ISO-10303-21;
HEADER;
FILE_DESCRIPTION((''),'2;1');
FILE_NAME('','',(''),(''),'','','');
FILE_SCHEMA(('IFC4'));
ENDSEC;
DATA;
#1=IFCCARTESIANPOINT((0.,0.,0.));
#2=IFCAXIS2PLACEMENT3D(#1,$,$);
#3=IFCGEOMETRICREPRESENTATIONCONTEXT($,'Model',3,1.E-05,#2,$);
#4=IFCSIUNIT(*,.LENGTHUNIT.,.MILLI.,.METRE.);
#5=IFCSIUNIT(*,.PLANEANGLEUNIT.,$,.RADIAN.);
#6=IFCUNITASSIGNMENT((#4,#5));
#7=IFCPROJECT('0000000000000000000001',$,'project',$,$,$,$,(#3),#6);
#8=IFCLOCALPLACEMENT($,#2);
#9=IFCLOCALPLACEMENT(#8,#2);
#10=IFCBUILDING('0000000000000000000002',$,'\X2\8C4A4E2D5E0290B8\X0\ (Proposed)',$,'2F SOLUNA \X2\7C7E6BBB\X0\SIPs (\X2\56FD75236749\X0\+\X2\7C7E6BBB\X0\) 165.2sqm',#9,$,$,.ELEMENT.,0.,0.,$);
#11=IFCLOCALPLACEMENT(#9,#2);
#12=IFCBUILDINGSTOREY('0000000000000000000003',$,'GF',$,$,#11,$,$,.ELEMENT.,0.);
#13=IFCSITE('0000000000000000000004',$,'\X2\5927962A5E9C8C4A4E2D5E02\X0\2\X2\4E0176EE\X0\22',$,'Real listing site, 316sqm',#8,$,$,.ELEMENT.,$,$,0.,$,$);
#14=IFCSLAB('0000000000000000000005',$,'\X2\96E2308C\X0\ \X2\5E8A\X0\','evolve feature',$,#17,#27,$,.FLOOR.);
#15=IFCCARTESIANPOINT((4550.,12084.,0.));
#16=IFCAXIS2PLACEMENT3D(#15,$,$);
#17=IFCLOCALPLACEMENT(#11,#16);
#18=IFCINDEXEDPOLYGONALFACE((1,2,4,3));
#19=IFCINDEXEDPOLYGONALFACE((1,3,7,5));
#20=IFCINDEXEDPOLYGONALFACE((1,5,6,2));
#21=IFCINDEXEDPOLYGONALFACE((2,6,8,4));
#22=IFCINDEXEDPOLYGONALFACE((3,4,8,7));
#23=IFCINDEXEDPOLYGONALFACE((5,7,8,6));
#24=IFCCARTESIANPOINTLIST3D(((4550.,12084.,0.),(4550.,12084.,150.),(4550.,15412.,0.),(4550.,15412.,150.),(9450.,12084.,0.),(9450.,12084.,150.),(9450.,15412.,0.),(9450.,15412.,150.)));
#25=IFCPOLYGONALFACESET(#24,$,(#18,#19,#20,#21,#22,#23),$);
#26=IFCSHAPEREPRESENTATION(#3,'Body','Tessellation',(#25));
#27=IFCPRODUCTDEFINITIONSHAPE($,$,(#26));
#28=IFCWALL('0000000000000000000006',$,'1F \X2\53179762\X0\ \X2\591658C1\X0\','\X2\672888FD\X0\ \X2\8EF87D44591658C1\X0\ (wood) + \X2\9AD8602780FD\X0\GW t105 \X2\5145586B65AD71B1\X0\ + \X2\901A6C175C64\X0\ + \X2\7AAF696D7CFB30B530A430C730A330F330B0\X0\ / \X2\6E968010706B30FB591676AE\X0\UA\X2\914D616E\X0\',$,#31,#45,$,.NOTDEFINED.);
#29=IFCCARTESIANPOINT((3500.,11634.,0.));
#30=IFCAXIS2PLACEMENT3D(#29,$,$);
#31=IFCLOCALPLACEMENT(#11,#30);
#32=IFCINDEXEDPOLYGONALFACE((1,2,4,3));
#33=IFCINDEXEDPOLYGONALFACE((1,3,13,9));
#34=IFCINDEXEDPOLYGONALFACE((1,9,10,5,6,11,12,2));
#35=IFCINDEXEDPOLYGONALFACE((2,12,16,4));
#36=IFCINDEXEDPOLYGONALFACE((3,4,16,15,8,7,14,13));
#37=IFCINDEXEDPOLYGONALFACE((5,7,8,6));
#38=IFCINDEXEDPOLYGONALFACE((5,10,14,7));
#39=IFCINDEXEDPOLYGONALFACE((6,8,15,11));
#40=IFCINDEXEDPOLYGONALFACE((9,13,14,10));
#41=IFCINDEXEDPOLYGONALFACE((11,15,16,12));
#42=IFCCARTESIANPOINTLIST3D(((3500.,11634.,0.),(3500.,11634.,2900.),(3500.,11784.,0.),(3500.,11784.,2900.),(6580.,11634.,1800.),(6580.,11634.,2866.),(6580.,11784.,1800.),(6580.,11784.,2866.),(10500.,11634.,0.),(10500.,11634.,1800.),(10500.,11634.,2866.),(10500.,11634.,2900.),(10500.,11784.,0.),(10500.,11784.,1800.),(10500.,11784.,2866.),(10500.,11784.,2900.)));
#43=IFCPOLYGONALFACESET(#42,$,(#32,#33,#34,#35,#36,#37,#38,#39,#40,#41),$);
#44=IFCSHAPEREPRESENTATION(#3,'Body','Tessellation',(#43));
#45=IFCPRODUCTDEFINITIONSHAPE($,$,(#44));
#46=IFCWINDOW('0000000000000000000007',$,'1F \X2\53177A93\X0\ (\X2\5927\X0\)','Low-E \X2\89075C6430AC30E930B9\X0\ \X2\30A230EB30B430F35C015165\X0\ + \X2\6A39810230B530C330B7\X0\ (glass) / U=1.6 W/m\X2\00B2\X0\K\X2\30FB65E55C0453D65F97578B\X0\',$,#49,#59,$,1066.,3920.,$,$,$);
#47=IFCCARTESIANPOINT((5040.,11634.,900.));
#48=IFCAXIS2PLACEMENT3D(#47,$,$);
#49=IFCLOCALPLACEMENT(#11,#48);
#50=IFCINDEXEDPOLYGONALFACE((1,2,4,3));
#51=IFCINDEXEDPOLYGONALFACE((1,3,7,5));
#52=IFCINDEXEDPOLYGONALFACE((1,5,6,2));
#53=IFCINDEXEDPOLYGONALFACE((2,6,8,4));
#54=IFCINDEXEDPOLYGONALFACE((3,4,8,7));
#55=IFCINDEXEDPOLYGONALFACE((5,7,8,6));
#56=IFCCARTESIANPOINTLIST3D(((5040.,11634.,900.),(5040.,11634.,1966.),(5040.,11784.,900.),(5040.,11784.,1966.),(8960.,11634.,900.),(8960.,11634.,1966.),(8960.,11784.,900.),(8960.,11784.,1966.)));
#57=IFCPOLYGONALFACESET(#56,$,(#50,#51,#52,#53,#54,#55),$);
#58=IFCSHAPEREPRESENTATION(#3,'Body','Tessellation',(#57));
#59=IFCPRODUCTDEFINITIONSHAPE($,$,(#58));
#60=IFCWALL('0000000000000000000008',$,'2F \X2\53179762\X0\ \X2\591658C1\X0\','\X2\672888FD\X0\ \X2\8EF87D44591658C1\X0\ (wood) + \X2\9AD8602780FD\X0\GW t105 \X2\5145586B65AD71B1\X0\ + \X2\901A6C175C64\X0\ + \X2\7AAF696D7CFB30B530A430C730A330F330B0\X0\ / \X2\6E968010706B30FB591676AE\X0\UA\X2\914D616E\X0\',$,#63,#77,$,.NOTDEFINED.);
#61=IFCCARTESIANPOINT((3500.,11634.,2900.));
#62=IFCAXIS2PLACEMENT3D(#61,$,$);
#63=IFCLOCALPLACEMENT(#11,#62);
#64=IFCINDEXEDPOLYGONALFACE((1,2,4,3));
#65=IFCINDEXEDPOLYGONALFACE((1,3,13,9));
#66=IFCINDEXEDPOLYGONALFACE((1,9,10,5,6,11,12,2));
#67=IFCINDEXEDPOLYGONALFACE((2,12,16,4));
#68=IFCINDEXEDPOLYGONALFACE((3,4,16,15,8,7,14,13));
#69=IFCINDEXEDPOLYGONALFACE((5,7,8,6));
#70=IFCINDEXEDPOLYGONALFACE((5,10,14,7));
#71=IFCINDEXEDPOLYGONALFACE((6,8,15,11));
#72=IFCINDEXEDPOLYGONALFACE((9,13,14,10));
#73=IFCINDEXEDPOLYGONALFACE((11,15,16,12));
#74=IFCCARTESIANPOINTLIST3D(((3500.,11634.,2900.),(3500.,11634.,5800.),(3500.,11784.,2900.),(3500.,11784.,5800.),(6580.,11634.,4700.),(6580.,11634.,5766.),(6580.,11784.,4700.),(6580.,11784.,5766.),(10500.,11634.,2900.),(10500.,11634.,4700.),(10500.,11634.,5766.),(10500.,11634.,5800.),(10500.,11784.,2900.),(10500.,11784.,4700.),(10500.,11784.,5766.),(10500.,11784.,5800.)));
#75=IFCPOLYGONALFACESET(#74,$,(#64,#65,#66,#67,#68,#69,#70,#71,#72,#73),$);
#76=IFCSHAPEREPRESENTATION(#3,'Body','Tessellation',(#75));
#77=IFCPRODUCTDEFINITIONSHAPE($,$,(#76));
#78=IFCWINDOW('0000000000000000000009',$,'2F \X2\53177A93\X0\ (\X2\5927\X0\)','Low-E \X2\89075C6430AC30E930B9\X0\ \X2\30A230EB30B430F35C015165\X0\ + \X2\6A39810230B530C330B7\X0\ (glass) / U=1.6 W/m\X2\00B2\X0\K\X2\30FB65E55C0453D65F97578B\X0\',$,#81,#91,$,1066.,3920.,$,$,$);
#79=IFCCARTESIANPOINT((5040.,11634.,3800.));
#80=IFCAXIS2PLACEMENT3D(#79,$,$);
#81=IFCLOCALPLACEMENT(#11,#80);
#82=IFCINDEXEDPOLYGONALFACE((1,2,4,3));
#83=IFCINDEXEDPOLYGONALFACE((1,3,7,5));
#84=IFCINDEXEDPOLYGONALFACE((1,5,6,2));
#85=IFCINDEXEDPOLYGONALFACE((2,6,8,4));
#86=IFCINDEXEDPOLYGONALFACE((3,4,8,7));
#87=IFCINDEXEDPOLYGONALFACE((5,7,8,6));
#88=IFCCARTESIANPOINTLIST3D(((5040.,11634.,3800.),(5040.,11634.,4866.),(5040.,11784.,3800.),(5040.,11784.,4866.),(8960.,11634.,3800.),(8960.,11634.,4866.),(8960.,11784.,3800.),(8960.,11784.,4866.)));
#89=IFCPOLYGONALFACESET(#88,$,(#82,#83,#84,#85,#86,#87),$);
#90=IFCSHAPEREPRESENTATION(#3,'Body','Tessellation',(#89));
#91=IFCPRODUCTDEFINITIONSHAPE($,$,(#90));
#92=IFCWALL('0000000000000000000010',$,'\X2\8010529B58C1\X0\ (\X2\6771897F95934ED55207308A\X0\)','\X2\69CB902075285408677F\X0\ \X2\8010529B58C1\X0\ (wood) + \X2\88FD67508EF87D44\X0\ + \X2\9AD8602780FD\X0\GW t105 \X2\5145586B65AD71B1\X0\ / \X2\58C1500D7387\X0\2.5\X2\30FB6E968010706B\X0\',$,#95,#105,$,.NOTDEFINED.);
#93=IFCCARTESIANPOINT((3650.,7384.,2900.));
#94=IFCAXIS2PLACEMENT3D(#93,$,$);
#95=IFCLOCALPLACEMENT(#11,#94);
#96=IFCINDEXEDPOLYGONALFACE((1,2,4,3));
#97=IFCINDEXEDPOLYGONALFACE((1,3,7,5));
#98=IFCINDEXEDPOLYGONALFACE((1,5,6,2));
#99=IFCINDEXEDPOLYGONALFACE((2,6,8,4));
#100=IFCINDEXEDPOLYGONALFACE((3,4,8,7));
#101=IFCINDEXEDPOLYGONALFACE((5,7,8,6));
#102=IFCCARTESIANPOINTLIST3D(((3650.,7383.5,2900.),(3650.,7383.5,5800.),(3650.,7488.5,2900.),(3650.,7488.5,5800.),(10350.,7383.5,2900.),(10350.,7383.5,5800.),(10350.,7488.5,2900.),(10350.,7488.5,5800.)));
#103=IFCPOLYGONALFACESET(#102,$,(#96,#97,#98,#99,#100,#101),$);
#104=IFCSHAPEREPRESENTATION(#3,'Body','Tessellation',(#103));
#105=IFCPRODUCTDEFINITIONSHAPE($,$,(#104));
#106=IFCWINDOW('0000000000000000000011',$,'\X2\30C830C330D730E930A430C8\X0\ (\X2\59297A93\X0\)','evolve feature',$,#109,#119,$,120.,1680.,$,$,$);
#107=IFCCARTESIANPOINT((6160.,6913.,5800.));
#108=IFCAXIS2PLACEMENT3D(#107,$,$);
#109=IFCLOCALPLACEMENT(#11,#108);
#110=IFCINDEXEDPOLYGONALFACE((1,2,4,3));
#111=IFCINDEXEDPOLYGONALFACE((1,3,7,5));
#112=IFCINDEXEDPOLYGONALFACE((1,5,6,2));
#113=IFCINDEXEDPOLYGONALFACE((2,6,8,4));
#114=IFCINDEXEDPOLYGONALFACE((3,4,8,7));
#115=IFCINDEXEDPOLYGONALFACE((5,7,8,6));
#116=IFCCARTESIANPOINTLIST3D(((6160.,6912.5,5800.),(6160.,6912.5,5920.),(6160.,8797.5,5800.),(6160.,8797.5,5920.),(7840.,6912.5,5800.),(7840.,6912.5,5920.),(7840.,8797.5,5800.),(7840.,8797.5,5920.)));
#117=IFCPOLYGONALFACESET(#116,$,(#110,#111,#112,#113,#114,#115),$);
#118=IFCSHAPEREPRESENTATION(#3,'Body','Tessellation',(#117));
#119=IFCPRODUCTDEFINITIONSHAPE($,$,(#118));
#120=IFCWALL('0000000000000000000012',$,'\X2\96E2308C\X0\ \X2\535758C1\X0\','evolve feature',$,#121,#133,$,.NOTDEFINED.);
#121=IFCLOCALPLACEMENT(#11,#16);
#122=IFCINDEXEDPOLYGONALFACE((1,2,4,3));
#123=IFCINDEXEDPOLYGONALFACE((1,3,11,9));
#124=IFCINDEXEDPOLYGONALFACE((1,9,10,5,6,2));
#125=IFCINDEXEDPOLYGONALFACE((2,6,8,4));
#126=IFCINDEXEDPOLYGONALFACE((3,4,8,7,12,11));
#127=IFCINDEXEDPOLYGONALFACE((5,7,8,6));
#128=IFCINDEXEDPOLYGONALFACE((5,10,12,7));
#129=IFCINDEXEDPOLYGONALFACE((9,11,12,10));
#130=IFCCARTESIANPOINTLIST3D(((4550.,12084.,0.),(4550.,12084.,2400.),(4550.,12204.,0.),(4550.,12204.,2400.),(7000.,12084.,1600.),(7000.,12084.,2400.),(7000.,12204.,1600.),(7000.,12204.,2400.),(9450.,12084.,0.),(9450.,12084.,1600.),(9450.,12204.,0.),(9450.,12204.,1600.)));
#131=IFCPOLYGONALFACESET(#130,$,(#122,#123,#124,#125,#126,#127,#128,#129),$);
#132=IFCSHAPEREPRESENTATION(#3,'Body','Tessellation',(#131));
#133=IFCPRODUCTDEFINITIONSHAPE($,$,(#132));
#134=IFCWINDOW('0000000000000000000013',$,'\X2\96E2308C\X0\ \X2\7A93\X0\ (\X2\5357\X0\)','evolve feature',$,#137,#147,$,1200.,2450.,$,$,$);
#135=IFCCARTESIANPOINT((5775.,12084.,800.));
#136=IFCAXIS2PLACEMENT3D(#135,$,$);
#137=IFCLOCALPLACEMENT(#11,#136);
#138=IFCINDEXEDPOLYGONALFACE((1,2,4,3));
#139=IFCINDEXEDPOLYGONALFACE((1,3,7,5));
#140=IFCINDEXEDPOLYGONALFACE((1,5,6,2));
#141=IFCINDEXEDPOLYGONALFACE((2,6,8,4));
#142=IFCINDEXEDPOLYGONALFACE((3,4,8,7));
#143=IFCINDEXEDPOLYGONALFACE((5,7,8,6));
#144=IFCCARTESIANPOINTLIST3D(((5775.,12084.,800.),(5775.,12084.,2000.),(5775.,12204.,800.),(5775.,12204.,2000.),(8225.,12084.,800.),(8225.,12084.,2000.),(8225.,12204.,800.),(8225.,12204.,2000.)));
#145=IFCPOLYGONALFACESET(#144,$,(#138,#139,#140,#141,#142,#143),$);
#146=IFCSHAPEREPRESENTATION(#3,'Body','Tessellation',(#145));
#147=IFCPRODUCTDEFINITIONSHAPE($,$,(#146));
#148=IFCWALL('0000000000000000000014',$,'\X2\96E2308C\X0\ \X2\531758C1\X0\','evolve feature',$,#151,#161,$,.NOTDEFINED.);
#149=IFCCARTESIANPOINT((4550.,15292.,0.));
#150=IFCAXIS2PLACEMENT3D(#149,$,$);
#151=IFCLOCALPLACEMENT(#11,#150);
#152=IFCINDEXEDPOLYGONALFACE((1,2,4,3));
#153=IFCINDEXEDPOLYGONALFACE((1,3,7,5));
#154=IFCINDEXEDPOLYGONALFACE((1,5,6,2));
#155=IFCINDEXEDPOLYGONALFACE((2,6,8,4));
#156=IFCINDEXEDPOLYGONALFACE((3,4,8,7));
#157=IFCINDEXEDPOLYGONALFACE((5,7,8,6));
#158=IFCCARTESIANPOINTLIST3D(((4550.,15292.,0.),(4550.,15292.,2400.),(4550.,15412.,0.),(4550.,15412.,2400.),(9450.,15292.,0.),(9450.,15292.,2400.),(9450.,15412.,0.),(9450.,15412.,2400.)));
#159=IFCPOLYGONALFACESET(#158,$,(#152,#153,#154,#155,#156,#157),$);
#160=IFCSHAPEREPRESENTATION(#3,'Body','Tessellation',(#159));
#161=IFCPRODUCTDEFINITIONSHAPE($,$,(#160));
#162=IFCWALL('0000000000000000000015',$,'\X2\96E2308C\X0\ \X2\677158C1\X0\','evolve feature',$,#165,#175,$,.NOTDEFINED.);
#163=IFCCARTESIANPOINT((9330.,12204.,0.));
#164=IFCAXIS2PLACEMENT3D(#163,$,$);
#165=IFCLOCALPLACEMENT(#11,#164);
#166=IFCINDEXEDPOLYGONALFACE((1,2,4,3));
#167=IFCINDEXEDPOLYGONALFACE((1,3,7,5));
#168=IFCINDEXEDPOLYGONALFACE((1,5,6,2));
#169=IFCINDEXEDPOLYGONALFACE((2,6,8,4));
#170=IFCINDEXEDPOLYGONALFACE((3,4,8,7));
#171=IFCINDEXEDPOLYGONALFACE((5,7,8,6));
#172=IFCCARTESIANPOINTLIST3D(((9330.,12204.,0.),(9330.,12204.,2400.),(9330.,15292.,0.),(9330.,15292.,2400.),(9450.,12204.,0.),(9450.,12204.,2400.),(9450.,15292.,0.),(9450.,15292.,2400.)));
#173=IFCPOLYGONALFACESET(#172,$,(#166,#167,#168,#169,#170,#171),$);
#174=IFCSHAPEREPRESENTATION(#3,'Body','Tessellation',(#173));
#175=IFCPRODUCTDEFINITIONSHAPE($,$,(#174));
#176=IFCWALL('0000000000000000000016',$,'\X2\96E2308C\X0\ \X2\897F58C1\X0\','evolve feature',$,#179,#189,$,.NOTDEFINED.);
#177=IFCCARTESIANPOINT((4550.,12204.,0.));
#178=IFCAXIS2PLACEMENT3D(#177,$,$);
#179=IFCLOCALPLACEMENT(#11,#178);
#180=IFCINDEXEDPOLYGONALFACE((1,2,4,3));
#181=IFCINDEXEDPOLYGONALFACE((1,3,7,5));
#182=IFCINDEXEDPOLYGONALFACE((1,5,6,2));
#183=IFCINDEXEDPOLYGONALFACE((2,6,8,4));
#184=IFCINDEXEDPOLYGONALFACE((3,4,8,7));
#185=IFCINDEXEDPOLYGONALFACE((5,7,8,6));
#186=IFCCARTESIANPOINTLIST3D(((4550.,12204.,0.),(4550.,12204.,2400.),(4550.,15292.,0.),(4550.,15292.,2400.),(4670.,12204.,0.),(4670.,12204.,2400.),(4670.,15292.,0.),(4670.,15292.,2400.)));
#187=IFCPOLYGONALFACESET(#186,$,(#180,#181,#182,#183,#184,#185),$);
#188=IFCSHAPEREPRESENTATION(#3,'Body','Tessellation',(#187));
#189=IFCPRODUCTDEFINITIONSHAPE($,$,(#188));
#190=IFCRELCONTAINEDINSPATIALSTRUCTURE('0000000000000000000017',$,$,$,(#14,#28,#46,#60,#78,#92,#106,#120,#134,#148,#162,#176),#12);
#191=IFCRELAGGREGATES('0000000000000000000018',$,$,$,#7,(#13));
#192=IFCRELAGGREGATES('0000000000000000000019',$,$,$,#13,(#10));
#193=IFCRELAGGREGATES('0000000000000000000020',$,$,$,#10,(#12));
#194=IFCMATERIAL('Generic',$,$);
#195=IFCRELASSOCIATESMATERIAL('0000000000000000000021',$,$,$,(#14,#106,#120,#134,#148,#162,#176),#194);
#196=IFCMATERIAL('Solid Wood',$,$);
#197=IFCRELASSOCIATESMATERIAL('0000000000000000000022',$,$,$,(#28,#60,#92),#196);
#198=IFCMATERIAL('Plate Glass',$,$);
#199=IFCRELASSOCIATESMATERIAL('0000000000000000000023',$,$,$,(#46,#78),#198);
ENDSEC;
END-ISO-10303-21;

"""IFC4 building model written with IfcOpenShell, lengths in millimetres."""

from ifc_helpers import new_model, si_unit, frame, frame_2d, origin, place, context, project, spatial, rectangle, extrude, material, element, fill, save


model = new_model("IFC4")

# Units and contexts
model_context = context("Model", 3, precision=1e-05, world=origin())
ifc_project = project(units=[si_unit("LENGTHUNIT", "METRE", prefix="MILLI"), si_unit("PLANEANGLEUNIT", "RADIAN")], contexts=[model_context])

# Site, building, storey
site_placement = place(None, origin())
site = spatial("IfcSite", under=ifc_project, at=site_placement, Name="大阪府豊中市2丁目22", ObjectType="Real listing site, 316sqm", CompositionType="ELEMENT", RefElevation=0.0)
building_placement = place(site_placement, origin())
building = spatial("IfcBuilding", under=site, at=building_placement, Name="豊中市邸 (Proposed)", ObjectType="2F SOLUNA 籾殻SIPs (国産杉+籾殻) 165.2sqm", CompositionType="ELEMENT", ElevationOfRefHeight=0.0, ElevationOfTerrain=0.0)
storey_placement = place(building_placement, origin())
storey = spatial("IfcBuildingStorey", under=building, at=storey_placement, Name="GF", CompositionType="ELEMENT", Elevation=0.0)

# Slab
ifc_material_1 = material(Name="Generic")
slab_placement = place(storey_placement, frame((4550.0, 12084.0, 0.0)))
element("IfcSlab", 1, at=slab_placement, inside=storey, material=ifc_material_1, Name="離れ 床", Description="evolve feature", PredefinedType="FLOOR", context=model_context, shape_type="SweptSolid", body=[
    extrude(rectangle(XDim=4900.0, YDim=3328.0, at=frame_2d((2450.0, 1664.0))), frame((4550.0, 12084.0, 0.0)), (0.0, 0.0, 1.0), 150.0),
])

# Wall, opening, window
ifc_material_2 = material(Name="Solid Wood")
wall_1_placement = place(storey_placement, frame((3500.0, 11634.0, 0.0)))
wall_1 = element("IfcWall", 2, at=wall_1_placement, inside=storey, material=ifc_material_2, Name="1F 北面 外壁", Description="木製 軸組外壁 (wood) + 高性能GW t105 充填断熱 + 通気層 + 窯業系サイディング / 準耐火・外皮UA配慮", PredefinedType="NOTDEFINED", context=model_context, shape_type="SweptSolid", body=[
    extrude(rectangle(XDim=7000.0, YDim=150.0, at=frame_2d((3500.0, 75.0))), frame((3500.0, 11634.0, 0.0)), (0.0, 0.0, 1.0), 2900.0),
])
opening_1_placement = place(storey_placement, frame((5040.0, 11634.0, 900.0)))
opening_1 = element("IfcOpeningElement", 3, at=opening_1_placement, cuts=wall_1, PredefinedType="NOTDEFINED", context=model_context, shape_type="SweptSolid", body=[
    extrude(rectangle(XDim=3920.0, YDim=150.0, at=frame_2d((1960.0, 75.0))), frame((5040.0, 11634.0, 900.0)), (0.0, 0.0, 1.0), 1066.0),
])
ifc_material_3 = material(Name="Plate Glass")
window_1_placement = place(storey_placement, frame((5040.0, 11634.0, 900.0)))
window_1 = element("IfcWindow", 4, at=window_1_placement, inside=storey, material=ifc_material_3, Name="1F 北窓 (大)", Description="Low-E 複層ガラス アルゴン封入 + 樹脂サッシ (glass) / U=1.6 W/m²K・日射取得型", OverallHeight=1066.0, OverallWidth=3920.0, context=model_context, shape_type="SweptSolid", body=[
    extrude(rectangle(XDim=3920.0, YDim=150.0, at=frame_2d((1960.0, 75.0))), frame((5040.0, 11634.0, 900.0)), (0.0, 0.0, 1.0), 1066.0),
])
fill(opening_1, window_1)

# Wall, opening, window
wall_2_placement = place(storey_placement, frame((3500.0, 11634.0, 2900.0)))
wall_2 = element("IfcWall", 5, at=wall_2_placement, inside=storey, material=ifc_material_2, Name="2F 北面 外壁", Description="木製 軸組外壁 (wood) + 高性能GW t105 充填断熱 + 通気層 + 窯業系サイディング / 準耐火・外皮UA配慮", PredefinedType="NOTDEFINED", context=model_context, shape_type="SweptSolid", body=[
    extrude(rectangle(XDim=7000.0, YDim=150.0, at=frame_2d((3500.0, 75.0))), frame((3500.0, 11634.0, 2900.0)), (0.0, 0.0, 1.0), 2900.0),
])
opening_2_placement = place(storey_placement, frame((5040.0, 11634.0, 3800.0)))
opening_2 = element("IfcOpeningElement", 6, at=opening_2_placement, cuts=wall_2, PredefinedType="NOTDEFINED", context=model_context, shape_type="SweptSolid", body=[
    extrude(rectangle(XDim=3920.0, YDim=150.0, at=frame_2d((1960.0, 75.0))), frame((5040.0, 11634.0, 3800.0)), (0.0, 0.0, 1.0), 1066.0),
])
window_2_placement = place(storey_placement, frame((5040.0, 11634.0, 3800.0)))
window_2 = element("IfcWindow", 7, at=window_2_placement, inside=storey, material=ifc_material_3, Name="2F 北窓 (大)", Description="Low-E 複層ガラス アルゴン封入 + 樹脂サッシ (glass) / U=1.6 W/m²K・日射取得型", OverallHeight=1066.0, OverallWidth=3920.0, context=model_context, shape_type="SweptSolid", body=[
    extrude(rectangle(XDim=3920.0, YDim=150.0, at=frame_2d((1960.0, 75.0))), frame((5040.0, 11634.0, 3800.0)), (0.0, 0.0, 1.0), 1066.0),
])
fill(opening_2, window_2)

# Wall
wall_3_placement = place(storey_placement, frame((3650.0, 7384.0, 2900.0)))
element("IfcWall", 8, at=wall_3_placement, inside=storey, material=ifc_material_2, Name="耐力壁 (東西間仕切り)", Description="構造用合板 耐力壁 (wood) + 製材軸組 + 高性能GW t105 充填断熱 / 壁倍率2.5・準耐火", PredefinedType="NOTDEFINED", context=model_context, shape_type="SweptSolid", body=[
    extrude(rectangle(XDim=6700.0, YDim=105.0, at=frame_2d((3350.0, 52.0))), frame((3650.0, 7384.0, 2900.0)), (0.0, 0.0, 1.0), 2900.0),
])

# Window
window_3_placement = place(storey_placement, frame((6160.0, 6913.0, 5800.0)))
element("IfcWindow", 9, at=window_3_placement, inside=storey, material=ifc_material_1, Name="トップライト (天窓)", Description="evolve feature", OverallHeight=120.0, OverallWidth=1680.0, context=model_context, shape_type="SweptSolid", body=[
    extrude(rectangle(XDim=1680.0, YDim=1885.0, at=frame_2d((840.0, 942.0))), frame((6160.0, 6913.0, 5800.0)), (0.0, 0.0, 1.0), 120.0),
])

# Wall, opening, window
wall_4_placement = place(storey_placement, frame((4550.0, 12084.0, 0.0)))
wall_4 = element("IfcWall", 10, at=wall_4_placement, inside=storey, material=ifc_material_1, Name="離れ 南壁", Description="evolve feature", PredefinedType="NOTDEFINED", context=model_context, shape_type="SweptSolid", body=[
    extrude(rectangle(XDim=4900.0, YDim=120.0, at=frame_2d((2450.0, 60.0))), frame((4550.0, 12084.0, 0.0)), (0.0, 0.0, 1.0), 2400.0),
])
opening_3_placement = place(storey_placement, frame((5775.0, 12084.0, 800.0)))
opening_3 = element("IfcOpeningElement", 11, at=opening_3_placement, cuts=wall_4, PredefinedType="NOTDEFINED", context=model_context, shape_type="SweptSolid", body=[
    extrude(rectangle(XDim=2450.0, YDim=120.0, at=frame_2d((1225.0, 60.0))), frame((5775.0, 12084.0, 800.0)), (0.0, 0.0, 1.0), 1200.0),
])
window_4_placement = place(storey_placement, frame((5775.0, 12084.0, 800.0)))
window_4 = element("IfcWindow", 12, at=window_4_placement, inside=storey, material=ifc_material_1, Name="離れ 窓 (南)", Description="evolve feature", OverallHeight=1200.0, OverallWidth=2450.0, context=model_context, shape_type="SweptSolid", body=[
    extrude(rectangle(XDim=2450.0, YDim=120.0, at=frame_2d((1225.0, 60.0))), frame((5775.0, 12084.0, 800.0)), (0.0, 0.0, 1.0), 1200.0),
])
fill(opening_3, window_4)

# Walls
wall_5_placement = place(storey_placement, frame((4550.0, 15292.0, 0.0)))
element("IfcWall", 13, at=wall_5_placement, inside=storey, material=ifc_material_1, Name="離れ 北壁", Description="evolve feature", PredefinedType="NOTDEFINED", context=model_context, shape_type="SweptSolid", body=[
    extrude(rectangle(XDim=4900.0, YDim=120.0, at=frame_2d((2450.0, 60.0))), frame((4550.0, 15292.0, 0.0)), (0.0, 0.0, 1.0), 2400.0),
])
wall_6_placement = place(storey_placement, frame((9330.0, 12204.0, 0.0)))
element("IfcWall", 14, at=wall_6_placement, inside=storey, material=ifc_material_1, Name="離れ 東壁", Description="evolve feature", PredefinedType="NOTDEFINED", context=model_context, shape_type="SweptSolid", body=[
    extrude(rectangle(XDim=120.0, YDim=3088.0, at=frame_2d((60.0, 1544.0))), frame((9330.0, 12204.0, 0.0)), (0.0, 0.0, 1.0), 2400.0),
])
wall_7_placement = place(storey_placement, frame((4550.0, 12204.0, 0.0)))
element("IfcWall", 15, at=wall_7_placement, inside=storey, material=ifc_material_1, Name="離れ 西壁", Description="evolve feature", PredefinedType="NOTDEFINED", context=model_context, shape_type="SweptSolid", body=[
    extrude(rectangle(XDim=120.0, YDim=3088.0, at=frame_2d((60.0, 1544.0))), frame((4550.0, 12204.0, 0.0)), (0.0, 0.0, 1.0), 2400.0),
])

save(model, "model.ifc")
